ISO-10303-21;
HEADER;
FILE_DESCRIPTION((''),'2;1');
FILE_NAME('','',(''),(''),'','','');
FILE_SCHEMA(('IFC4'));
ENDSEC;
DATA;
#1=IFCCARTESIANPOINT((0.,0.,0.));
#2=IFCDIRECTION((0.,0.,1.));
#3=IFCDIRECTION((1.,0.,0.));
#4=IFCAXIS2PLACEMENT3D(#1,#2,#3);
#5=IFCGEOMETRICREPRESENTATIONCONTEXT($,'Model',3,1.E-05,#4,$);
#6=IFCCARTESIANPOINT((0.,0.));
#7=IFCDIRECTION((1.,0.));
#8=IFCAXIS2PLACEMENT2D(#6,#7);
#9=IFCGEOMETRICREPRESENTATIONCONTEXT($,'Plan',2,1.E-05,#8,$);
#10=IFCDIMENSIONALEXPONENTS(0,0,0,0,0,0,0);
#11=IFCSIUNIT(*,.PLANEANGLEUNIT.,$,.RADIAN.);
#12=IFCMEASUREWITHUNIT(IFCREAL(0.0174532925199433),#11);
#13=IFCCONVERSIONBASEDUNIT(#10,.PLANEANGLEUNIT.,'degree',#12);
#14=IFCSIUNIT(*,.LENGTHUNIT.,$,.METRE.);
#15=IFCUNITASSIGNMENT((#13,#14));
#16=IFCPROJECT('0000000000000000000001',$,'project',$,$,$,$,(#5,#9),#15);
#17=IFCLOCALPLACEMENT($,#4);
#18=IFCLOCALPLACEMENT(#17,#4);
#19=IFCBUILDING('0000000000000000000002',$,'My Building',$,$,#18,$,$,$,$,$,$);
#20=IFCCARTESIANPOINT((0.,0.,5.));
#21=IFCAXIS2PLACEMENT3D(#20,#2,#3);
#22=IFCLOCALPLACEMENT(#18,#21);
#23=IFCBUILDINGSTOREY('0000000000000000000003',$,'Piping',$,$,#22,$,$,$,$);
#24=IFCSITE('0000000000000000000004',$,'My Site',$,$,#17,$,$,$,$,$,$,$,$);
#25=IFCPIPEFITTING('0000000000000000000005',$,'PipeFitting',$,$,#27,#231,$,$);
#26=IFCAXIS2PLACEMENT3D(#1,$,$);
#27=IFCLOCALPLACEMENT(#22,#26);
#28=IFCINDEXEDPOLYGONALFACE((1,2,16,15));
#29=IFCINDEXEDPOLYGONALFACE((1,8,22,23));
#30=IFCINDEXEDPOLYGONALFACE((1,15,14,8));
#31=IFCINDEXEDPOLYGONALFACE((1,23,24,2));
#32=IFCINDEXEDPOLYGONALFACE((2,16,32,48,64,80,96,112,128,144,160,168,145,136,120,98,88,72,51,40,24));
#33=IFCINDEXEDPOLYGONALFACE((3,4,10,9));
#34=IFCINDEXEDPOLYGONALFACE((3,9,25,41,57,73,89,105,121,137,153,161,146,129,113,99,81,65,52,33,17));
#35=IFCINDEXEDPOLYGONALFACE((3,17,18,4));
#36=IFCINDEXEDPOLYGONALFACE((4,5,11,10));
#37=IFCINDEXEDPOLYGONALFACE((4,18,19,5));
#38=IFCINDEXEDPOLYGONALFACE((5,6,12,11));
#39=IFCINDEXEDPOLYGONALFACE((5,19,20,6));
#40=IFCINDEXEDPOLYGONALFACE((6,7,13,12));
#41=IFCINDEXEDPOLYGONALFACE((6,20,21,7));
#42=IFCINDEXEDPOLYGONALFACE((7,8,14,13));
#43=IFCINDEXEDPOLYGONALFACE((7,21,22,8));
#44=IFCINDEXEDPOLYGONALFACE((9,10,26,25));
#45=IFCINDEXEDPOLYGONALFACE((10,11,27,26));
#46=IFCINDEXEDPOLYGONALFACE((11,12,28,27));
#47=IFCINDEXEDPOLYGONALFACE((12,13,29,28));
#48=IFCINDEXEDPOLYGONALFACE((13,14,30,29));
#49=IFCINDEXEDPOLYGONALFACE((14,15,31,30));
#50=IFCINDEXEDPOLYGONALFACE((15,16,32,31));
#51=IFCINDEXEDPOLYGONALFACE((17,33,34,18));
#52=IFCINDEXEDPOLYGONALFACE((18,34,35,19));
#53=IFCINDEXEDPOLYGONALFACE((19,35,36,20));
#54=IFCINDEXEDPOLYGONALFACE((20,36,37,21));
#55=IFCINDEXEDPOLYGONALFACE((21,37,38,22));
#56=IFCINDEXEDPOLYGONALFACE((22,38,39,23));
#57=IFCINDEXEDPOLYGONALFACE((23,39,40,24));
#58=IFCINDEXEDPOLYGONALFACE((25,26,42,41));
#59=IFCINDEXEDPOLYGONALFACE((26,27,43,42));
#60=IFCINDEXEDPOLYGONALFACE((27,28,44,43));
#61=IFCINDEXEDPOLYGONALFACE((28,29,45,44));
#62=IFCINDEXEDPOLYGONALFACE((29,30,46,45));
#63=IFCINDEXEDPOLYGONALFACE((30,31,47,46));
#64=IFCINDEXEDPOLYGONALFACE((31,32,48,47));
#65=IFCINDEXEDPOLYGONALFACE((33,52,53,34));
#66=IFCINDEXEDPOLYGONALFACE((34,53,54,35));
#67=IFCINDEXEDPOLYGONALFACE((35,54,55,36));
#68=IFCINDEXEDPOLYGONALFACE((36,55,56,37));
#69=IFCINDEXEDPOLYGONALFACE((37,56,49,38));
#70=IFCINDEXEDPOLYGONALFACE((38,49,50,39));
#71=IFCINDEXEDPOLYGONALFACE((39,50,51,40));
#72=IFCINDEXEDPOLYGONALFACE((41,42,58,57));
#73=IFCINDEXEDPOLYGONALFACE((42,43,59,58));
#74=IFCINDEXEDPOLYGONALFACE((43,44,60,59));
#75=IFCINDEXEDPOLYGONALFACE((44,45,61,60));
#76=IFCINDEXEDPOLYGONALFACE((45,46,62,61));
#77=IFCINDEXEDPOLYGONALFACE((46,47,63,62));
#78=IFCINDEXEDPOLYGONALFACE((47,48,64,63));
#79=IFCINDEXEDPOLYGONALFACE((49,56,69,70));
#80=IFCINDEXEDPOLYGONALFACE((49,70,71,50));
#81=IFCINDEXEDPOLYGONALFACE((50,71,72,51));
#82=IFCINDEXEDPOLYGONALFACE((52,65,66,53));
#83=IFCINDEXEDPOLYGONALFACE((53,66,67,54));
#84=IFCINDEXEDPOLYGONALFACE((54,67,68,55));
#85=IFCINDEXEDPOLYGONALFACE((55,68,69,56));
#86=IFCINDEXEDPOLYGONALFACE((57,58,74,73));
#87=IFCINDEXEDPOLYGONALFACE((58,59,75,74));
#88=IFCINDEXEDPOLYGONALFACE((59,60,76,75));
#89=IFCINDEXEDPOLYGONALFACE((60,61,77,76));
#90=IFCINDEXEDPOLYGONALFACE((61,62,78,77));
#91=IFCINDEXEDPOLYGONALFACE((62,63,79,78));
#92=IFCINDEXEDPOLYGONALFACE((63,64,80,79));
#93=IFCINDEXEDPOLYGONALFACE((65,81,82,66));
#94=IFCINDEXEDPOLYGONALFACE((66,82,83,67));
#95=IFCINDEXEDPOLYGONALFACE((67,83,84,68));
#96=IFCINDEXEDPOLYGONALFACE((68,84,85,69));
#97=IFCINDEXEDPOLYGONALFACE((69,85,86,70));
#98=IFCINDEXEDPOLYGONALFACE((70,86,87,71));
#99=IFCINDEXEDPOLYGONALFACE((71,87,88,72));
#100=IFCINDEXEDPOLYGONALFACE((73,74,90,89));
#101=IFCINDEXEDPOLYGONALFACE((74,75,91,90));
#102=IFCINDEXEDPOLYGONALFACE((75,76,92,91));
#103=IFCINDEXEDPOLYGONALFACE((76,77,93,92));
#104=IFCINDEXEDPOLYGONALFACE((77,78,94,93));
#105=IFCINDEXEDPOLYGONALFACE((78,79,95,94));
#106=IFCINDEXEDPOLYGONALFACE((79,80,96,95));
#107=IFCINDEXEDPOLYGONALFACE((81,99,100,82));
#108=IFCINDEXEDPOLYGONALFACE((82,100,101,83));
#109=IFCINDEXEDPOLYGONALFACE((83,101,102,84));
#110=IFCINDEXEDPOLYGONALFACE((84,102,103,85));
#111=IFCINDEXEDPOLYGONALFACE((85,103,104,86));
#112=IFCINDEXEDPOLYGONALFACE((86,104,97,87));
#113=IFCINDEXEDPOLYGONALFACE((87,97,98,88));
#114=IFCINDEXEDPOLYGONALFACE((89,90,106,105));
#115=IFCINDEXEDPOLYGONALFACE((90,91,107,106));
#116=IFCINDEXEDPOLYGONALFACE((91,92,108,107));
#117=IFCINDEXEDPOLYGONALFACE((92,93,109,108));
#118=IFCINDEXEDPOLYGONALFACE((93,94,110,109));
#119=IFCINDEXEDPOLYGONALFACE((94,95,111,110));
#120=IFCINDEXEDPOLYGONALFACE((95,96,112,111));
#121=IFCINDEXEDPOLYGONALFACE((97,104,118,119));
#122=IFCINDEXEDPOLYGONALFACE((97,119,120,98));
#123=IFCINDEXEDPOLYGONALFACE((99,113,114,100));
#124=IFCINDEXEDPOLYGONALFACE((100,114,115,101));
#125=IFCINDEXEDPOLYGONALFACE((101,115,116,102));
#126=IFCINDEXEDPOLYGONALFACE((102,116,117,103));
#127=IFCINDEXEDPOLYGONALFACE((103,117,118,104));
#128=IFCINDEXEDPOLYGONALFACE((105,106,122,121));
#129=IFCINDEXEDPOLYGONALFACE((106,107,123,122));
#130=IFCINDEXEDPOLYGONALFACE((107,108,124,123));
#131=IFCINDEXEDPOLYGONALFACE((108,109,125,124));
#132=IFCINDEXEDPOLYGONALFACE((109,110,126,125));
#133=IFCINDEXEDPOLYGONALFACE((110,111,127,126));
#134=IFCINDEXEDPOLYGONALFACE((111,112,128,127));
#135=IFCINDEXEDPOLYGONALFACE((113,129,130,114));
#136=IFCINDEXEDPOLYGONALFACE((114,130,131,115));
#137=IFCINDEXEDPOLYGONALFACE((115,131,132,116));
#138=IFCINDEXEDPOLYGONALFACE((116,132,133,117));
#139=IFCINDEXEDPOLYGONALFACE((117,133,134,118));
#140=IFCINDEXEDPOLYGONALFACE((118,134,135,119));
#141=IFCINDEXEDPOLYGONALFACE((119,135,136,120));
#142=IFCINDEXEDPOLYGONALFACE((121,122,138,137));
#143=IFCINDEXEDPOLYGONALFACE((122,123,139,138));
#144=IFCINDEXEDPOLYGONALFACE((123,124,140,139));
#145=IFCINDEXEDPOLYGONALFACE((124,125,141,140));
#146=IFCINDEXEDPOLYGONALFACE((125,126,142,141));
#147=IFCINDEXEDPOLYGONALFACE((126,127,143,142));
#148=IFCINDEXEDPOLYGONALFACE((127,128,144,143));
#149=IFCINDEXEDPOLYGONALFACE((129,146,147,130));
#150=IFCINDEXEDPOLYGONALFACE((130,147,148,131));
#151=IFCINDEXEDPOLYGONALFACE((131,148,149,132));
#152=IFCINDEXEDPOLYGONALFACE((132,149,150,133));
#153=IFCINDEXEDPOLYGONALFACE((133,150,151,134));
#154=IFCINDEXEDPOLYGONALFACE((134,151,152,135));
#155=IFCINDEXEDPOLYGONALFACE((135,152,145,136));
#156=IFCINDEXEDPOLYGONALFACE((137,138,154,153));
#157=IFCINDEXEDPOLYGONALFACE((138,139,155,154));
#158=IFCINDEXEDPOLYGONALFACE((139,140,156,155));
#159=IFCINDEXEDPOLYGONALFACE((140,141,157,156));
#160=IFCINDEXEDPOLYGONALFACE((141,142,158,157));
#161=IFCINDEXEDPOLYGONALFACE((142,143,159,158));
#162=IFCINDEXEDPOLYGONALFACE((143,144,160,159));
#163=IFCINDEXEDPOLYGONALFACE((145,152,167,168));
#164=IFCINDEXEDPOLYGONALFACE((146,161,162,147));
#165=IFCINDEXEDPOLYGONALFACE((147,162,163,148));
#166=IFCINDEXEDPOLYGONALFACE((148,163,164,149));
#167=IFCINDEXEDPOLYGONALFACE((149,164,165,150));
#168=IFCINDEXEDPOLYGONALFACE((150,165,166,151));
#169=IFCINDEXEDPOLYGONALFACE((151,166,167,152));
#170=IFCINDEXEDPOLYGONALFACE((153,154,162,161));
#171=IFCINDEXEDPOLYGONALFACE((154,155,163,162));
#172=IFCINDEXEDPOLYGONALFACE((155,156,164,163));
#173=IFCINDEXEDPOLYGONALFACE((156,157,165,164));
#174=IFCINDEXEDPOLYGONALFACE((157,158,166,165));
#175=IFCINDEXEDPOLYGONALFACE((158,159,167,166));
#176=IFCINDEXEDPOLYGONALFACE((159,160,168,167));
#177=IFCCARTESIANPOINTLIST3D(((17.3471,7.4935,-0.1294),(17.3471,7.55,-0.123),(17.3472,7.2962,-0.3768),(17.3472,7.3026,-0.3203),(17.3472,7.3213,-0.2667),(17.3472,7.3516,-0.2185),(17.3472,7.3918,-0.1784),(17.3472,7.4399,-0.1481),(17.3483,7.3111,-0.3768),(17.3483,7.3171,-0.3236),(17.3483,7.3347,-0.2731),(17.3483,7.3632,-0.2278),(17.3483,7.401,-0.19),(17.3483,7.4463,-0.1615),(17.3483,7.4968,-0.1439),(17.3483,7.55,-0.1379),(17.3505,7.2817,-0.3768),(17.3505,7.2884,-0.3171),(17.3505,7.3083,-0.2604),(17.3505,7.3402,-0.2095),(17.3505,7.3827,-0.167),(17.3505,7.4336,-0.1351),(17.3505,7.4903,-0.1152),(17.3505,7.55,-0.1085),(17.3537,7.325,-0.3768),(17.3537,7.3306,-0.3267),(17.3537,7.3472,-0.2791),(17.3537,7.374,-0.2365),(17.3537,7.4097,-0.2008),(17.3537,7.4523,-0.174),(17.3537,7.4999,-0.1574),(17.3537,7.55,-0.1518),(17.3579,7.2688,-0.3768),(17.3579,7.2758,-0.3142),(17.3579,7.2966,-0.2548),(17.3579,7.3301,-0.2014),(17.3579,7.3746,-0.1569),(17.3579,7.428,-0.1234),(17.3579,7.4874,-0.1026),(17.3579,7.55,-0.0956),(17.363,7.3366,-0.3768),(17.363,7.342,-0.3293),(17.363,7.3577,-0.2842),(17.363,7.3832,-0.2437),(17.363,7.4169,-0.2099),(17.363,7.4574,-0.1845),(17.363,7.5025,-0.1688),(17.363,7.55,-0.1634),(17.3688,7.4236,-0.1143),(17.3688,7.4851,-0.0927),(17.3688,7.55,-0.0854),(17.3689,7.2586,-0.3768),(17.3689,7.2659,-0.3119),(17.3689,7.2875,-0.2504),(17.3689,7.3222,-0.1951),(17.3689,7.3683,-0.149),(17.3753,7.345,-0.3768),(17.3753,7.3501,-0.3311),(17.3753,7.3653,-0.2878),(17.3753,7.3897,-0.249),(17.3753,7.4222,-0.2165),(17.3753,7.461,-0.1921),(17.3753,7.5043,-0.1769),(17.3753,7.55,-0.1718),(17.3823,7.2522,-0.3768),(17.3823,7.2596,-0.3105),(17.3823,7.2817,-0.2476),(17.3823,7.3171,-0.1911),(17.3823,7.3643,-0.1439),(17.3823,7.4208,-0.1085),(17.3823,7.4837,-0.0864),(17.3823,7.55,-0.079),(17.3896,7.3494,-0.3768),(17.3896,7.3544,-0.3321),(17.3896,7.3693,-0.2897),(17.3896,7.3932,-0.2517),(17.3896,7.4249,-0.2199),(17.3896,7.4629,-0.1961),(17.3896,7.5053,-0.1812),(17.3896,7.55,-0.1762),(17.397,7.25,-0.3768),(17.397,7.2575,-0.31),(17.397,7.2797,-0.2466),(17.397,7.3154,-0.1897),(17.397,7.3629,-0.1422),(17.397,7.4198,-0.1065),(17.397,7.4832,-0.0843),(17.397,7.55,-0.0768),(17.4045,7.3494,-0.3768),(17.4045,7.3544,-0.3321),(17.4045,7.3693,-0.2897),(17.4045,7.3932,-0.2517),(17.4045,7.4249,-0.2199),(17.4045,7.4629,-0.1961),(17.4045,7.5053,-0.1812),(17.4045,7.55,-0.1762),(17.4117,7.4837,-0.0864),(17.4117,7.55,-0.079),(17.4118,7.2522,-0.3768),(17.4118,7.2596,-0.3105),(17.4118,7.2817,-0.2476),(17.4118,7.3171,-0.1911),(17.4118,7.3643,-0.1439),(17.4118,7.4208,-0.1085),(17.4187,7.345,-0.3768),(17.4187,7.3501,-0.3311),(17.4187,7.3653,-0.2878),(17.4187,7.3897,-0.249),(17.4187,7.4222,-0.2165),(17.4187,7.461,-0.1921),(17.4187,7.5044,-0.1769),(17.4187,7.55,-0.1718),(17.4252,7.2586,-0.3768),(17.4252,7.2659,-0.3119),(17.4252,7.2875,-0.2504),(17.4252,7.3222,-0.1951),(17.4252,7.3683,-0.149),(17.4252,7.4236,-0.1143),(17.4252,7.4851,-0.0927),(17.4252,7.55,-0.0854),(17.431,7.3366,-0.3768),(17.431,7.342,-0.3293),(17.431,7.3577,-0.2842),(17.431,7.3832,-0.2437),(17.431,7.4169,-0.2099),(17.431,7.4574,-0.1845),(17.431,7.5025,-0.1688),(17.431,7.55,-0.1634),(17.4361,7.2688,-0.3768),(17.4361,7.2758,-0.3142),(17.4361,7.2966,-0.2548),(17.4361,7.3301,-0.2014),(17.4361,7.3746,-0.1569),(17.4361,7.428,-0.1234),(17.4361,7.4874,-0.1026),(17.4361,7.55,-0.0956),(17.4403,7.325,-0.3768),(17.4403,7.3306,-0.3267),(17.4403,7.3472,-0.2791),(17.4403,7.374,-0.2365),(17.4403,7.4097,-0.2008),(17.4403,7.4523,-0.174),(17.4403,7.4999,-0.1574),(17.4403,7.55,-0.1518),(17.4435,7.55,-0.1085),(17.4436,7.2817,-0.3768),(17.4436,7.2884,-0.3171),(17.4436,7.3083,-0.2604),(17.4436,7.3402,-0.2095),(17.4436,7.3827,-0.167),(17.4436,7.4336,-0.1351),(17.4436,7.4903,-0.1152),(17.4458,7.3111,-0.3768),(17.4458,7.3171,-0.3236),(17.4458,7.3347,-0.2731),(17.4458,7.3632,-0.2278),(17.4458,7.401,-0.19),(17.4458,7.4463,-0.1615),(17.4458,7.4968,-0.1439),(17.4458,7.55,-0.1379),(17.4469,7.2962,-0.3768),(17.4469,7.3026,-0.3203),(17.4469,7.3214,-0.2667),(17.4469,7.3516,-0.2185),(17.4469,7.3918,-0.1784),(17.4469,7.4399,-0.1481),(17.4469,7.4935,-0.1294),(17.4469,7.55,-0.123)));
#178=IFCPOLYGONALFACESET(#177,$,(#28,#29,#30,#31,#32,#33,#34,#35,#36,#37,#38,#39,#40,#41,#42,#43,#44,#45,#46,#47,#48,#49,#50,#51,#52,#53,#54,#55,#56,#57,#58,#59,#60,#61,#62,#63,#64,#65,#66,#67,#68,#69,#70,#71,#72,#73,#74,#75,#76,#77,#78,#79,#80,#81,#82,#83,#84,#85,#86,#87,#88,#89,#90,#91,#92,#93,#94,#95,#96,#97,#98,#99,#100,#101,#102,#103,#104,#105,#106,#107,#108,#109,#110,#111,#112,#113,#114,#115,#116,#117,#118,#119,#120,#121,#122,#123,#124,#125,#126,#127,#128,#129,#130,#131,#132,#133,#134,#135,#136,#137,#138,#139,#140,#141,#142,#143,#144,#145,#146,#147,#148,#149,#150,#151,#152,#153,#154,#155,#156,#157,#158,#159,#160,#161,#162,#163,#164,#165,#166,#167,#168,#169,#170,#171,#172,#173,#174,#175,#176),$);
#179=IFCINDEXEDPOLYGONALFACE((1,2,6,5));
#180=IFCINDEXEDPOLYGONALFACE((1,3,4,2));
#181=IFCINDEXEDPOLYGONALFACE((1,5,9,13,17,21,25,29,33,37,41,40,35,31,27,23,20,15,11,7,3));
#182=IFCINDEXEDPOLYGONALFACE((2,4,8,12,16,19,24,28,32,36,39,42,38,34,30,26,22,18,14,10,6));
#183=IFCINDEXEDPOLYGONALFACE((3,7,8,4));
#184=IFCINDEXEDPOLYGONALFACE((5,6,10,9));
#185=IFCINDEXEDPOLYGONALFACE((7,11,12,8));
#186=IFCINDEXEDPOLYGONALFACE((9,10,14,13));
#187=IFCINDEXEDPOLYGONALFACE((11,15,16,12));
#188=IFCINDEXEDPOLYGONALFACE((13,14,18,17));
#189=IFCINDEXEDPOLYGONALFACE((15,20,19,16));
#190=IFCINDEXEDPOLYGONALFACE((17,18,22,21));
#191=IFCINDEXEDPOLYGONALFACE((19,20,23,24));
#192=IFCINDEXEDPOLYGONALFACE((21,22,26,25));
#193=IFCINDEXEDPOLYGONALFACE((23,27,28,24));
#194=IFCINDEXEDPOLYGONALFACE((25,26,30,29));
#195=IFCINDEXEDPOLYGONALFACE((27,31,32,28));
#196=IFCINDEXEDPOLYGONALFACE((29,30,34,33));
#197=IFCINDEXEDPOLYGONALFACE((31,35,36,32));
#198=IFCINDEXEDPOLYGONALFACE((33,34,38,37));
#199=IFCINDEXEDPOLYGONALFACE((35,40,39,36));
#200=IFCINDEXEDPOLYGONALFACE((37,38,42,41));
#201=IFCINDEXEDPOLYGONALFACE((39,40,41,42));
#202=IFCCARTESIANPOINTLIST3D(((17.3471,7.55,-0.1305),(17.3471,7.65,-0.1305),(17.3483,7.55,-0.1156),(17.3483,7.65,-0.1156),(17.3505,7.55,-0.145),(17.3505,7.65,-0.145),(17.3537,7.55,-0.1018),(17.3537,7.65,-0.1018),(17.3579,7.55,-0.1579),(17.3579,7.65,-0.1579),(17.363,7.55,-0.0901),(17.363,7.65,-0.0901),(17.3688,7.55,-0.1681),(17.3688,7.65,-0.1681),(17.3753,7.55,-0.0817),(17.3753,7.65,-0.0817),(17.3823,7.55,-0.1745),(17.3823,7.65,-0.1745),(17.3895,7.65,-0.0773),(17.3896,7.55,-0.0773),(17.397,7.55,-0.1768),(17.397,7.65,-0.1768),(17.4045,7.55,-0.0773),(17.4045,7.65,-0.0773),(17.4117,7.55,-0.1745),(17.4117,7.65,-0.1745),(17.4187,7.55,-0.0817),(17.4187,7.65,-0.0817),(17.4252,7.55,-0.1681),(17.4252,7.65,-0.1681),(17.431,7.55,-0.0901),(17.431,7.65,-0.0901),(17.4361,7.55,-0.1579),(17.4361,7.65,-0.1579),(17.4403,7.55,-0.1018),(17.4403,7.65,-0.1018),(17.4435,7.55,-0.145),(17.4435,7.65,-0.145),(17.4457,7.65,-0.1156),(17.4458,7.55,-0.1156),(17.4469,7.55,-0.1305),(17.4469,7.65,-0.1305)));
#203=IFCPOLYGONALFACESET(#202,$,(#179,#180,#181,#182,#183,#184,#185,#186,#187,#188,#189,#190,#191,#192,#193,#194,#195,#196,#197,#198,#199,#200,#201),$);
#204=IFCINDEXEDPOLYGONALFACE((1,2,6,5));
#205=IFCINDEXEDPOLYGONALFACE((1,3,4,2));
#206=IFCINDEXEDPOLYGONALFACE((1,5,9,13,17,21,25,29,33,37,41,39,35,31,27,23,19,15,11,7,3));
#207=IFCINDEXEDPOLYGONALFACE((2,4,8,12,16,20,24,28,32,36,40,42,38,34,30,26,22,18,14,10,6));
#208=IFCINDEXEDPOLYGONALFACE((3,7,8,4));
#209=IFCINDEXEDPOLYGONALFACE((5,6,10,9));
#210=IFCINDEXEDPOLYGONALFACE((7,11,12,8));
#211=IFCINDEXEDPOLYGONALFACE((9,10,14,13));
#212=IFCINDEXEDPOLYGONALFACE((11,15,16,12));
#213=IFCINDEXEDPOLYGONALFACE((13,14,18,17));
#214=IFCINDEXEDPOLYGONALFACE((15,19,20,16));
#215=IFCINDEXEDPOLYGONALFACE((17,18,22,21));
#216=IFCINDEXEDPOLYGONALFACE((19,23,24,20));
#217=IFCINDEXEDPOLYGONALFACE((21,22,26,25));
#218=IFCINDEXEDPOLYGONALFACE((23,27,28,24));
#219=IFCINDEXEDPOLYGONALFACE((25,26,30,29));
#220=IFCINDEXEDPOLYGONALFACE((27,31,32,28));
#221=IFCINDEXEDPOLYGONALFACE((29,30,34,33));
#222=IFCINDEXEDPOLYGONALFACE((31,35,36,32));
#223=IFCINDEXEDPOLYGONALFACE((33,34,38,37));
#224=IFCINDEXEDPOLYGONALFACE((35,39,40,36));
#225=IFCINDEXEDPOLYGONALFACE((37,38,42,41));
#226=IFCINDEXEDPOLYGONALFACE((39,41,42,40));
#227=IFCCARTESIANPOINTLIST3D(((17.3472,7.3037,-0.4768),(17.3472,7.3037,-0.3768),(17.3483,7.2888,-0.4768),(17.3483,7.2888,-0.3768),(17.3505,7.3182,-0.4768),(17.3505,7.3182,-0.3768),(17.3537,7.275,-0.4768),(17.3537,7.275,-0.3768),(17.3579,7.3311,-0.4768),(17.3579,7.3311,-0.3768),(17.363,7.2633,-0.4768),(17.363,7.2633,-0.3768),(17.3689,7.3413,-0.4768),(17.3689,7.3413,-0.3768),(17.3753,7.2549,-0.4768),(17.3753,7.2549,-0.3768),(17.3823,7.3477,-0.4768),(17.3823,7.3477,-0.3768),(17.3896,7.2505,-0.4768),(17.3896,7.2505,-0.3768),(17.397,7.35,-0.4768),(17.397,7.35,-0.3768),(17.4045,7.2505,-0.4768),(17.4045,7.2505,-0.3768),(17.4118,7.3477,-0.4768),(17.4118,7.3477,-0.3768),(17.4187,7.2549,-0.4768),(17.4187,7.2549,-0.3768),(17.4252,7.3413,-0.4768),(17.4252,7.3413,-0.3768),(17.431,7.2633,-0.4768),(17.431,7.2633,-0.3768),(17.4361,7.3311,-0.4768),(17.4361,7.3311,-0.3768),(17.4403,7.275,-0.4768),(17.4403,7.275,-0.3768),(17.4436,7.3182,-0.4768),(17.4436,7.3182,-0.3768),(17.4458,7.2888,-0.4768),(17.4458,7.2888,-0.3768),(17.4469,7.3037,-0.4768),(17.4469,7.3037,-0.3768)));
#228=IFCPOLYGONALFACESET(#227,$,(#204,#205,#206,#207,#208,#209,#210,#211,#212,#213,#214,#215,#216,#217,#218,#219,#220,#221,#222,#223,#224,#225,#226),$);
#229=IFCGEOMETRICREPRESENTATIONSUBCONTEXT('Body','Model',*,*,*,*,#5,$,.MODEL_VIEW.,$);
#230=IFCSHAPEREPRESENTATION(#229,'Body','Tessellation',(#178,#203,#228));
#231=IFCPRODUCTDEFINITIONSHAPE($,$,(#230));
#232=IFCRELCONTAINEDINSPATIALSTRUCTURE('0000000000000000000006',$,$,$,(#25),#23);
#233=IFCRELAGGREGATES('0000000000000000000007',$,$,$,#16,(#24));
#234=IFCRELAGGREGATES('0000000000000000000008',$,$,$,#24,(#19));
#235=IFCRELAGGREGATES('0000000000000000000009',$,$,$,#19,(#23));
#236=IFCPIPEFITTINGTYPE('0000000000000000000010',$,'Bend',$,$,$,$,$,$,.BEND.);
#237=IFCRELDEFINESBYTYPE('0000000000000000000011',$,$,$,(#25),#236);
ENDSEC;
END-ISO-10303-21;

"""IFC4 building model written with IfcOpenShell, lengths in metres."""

from ifc_helpers import new_model, entity, si_unit, converted_unit, frame, origin_with_axes, origin_2d_with_axis, place, context, subcontext, project, spatial, circle, extrude, source, transform, mapped, type_object, type_shapes, element, save


model = new_model("IFC4")

# Units and contexts
model_context = context("Model", 3, precision=1e-05, world=origin_with_axes())
plan_context = context("Plan", 2, precision=1e-05, world=origin_2d_with_axis())
body_context = subcontext(model_context, "Body", "Model", "MODEL_VIEW")
ifc_project = project(units=[converted_unit("PLANEANGLEUNIT", "degree", entity("IfcReal", 0.0174532925199433), si_unit("PLANEANGLEUNIT", "RADIAN"), dimensions=[0, 0, 0, 0, 0, 0, 0]), si_unit("LENGTHUNIT", "METRE")], contexts=[model_context, plan_context])

# Site, building, storey
site_placement = place(None, origin_with_axes())
site = spatial("IfcSite", under=ifc_project, at=site_placement, Name="My Site")
building_placement = place(site_placement, origin_with_axes())
building = spatial("IfcBuilding", under=site, at=building_placement, Name="My Building")
storey_placement = place(building_placement, frame((0.0, 0.0, 5.0), z_axis=(0.0, 0.0, 1.0), x_axis=(1.0, 0.0, 0.0)))
storey = spatial("IfcBuildingStorey", under=building, at=storey_placement, Name="Piping")

# Pipe fitting
pipe_fitting_type_1 = type_object("IfcPipeFittingType", Name="Bend", PredefinedType="BEND")
shared_shape = source(origin_with_axes(), body_context, "Body", "SolidModel", [
    entity("IfcSweptDiskSolid", entity("IfcIndexedPolyCurve", entity("IfcCartesianPointList3D", [[0.0, 0.0, -0.1], [0.0732, 0.0, -0.2768], [0.25, 0.0, -0.35]]), [entity("IfcArcIndex", [1, 2, 3])]), 0.05),
    extrude(circle(Radius=0.05), origin_with_axes(), (0.0, 0.0, -1.0), 0.1),
    extrude(circle(Radius=0.05), frame((0.25, 0.0, -0.35), z_axis=(1.0, 0.0, 0.0), x_axis=(0.0, 0.0, 1.0)), (0.0, 0.0, 1.0), 0.1),
])
type_shapes(pipe_fitting_type_1, [shared_shape])
for number, where, z_axis, x_axis, name in (
    (1, (17.397, 7.65, -0.1268), (-0.00006, 1.0, 0.0), (0.0, 0.0, -1.0), "PipeFitting"),
):
    element("IfcPipeFitting", number, at=place(storey_placement, frame(where, z_axis=z_axis, x_axis=x_axis)), inside=storey, type_object=pipe_fitting_type_1, Name=name, context=body_context, shape_type="MappedRepresentation", body=[
        mapped(shared_shape, transform((0.0, 0.0, 0.0), x_axis=(1.0, 0.0, 0.0), y_axis=(0.0, 1.0, 0.0), z_axis=(0.0, 0.0, 1.0), scale=1.0)),
    ])

save(model, "model.ifc")
